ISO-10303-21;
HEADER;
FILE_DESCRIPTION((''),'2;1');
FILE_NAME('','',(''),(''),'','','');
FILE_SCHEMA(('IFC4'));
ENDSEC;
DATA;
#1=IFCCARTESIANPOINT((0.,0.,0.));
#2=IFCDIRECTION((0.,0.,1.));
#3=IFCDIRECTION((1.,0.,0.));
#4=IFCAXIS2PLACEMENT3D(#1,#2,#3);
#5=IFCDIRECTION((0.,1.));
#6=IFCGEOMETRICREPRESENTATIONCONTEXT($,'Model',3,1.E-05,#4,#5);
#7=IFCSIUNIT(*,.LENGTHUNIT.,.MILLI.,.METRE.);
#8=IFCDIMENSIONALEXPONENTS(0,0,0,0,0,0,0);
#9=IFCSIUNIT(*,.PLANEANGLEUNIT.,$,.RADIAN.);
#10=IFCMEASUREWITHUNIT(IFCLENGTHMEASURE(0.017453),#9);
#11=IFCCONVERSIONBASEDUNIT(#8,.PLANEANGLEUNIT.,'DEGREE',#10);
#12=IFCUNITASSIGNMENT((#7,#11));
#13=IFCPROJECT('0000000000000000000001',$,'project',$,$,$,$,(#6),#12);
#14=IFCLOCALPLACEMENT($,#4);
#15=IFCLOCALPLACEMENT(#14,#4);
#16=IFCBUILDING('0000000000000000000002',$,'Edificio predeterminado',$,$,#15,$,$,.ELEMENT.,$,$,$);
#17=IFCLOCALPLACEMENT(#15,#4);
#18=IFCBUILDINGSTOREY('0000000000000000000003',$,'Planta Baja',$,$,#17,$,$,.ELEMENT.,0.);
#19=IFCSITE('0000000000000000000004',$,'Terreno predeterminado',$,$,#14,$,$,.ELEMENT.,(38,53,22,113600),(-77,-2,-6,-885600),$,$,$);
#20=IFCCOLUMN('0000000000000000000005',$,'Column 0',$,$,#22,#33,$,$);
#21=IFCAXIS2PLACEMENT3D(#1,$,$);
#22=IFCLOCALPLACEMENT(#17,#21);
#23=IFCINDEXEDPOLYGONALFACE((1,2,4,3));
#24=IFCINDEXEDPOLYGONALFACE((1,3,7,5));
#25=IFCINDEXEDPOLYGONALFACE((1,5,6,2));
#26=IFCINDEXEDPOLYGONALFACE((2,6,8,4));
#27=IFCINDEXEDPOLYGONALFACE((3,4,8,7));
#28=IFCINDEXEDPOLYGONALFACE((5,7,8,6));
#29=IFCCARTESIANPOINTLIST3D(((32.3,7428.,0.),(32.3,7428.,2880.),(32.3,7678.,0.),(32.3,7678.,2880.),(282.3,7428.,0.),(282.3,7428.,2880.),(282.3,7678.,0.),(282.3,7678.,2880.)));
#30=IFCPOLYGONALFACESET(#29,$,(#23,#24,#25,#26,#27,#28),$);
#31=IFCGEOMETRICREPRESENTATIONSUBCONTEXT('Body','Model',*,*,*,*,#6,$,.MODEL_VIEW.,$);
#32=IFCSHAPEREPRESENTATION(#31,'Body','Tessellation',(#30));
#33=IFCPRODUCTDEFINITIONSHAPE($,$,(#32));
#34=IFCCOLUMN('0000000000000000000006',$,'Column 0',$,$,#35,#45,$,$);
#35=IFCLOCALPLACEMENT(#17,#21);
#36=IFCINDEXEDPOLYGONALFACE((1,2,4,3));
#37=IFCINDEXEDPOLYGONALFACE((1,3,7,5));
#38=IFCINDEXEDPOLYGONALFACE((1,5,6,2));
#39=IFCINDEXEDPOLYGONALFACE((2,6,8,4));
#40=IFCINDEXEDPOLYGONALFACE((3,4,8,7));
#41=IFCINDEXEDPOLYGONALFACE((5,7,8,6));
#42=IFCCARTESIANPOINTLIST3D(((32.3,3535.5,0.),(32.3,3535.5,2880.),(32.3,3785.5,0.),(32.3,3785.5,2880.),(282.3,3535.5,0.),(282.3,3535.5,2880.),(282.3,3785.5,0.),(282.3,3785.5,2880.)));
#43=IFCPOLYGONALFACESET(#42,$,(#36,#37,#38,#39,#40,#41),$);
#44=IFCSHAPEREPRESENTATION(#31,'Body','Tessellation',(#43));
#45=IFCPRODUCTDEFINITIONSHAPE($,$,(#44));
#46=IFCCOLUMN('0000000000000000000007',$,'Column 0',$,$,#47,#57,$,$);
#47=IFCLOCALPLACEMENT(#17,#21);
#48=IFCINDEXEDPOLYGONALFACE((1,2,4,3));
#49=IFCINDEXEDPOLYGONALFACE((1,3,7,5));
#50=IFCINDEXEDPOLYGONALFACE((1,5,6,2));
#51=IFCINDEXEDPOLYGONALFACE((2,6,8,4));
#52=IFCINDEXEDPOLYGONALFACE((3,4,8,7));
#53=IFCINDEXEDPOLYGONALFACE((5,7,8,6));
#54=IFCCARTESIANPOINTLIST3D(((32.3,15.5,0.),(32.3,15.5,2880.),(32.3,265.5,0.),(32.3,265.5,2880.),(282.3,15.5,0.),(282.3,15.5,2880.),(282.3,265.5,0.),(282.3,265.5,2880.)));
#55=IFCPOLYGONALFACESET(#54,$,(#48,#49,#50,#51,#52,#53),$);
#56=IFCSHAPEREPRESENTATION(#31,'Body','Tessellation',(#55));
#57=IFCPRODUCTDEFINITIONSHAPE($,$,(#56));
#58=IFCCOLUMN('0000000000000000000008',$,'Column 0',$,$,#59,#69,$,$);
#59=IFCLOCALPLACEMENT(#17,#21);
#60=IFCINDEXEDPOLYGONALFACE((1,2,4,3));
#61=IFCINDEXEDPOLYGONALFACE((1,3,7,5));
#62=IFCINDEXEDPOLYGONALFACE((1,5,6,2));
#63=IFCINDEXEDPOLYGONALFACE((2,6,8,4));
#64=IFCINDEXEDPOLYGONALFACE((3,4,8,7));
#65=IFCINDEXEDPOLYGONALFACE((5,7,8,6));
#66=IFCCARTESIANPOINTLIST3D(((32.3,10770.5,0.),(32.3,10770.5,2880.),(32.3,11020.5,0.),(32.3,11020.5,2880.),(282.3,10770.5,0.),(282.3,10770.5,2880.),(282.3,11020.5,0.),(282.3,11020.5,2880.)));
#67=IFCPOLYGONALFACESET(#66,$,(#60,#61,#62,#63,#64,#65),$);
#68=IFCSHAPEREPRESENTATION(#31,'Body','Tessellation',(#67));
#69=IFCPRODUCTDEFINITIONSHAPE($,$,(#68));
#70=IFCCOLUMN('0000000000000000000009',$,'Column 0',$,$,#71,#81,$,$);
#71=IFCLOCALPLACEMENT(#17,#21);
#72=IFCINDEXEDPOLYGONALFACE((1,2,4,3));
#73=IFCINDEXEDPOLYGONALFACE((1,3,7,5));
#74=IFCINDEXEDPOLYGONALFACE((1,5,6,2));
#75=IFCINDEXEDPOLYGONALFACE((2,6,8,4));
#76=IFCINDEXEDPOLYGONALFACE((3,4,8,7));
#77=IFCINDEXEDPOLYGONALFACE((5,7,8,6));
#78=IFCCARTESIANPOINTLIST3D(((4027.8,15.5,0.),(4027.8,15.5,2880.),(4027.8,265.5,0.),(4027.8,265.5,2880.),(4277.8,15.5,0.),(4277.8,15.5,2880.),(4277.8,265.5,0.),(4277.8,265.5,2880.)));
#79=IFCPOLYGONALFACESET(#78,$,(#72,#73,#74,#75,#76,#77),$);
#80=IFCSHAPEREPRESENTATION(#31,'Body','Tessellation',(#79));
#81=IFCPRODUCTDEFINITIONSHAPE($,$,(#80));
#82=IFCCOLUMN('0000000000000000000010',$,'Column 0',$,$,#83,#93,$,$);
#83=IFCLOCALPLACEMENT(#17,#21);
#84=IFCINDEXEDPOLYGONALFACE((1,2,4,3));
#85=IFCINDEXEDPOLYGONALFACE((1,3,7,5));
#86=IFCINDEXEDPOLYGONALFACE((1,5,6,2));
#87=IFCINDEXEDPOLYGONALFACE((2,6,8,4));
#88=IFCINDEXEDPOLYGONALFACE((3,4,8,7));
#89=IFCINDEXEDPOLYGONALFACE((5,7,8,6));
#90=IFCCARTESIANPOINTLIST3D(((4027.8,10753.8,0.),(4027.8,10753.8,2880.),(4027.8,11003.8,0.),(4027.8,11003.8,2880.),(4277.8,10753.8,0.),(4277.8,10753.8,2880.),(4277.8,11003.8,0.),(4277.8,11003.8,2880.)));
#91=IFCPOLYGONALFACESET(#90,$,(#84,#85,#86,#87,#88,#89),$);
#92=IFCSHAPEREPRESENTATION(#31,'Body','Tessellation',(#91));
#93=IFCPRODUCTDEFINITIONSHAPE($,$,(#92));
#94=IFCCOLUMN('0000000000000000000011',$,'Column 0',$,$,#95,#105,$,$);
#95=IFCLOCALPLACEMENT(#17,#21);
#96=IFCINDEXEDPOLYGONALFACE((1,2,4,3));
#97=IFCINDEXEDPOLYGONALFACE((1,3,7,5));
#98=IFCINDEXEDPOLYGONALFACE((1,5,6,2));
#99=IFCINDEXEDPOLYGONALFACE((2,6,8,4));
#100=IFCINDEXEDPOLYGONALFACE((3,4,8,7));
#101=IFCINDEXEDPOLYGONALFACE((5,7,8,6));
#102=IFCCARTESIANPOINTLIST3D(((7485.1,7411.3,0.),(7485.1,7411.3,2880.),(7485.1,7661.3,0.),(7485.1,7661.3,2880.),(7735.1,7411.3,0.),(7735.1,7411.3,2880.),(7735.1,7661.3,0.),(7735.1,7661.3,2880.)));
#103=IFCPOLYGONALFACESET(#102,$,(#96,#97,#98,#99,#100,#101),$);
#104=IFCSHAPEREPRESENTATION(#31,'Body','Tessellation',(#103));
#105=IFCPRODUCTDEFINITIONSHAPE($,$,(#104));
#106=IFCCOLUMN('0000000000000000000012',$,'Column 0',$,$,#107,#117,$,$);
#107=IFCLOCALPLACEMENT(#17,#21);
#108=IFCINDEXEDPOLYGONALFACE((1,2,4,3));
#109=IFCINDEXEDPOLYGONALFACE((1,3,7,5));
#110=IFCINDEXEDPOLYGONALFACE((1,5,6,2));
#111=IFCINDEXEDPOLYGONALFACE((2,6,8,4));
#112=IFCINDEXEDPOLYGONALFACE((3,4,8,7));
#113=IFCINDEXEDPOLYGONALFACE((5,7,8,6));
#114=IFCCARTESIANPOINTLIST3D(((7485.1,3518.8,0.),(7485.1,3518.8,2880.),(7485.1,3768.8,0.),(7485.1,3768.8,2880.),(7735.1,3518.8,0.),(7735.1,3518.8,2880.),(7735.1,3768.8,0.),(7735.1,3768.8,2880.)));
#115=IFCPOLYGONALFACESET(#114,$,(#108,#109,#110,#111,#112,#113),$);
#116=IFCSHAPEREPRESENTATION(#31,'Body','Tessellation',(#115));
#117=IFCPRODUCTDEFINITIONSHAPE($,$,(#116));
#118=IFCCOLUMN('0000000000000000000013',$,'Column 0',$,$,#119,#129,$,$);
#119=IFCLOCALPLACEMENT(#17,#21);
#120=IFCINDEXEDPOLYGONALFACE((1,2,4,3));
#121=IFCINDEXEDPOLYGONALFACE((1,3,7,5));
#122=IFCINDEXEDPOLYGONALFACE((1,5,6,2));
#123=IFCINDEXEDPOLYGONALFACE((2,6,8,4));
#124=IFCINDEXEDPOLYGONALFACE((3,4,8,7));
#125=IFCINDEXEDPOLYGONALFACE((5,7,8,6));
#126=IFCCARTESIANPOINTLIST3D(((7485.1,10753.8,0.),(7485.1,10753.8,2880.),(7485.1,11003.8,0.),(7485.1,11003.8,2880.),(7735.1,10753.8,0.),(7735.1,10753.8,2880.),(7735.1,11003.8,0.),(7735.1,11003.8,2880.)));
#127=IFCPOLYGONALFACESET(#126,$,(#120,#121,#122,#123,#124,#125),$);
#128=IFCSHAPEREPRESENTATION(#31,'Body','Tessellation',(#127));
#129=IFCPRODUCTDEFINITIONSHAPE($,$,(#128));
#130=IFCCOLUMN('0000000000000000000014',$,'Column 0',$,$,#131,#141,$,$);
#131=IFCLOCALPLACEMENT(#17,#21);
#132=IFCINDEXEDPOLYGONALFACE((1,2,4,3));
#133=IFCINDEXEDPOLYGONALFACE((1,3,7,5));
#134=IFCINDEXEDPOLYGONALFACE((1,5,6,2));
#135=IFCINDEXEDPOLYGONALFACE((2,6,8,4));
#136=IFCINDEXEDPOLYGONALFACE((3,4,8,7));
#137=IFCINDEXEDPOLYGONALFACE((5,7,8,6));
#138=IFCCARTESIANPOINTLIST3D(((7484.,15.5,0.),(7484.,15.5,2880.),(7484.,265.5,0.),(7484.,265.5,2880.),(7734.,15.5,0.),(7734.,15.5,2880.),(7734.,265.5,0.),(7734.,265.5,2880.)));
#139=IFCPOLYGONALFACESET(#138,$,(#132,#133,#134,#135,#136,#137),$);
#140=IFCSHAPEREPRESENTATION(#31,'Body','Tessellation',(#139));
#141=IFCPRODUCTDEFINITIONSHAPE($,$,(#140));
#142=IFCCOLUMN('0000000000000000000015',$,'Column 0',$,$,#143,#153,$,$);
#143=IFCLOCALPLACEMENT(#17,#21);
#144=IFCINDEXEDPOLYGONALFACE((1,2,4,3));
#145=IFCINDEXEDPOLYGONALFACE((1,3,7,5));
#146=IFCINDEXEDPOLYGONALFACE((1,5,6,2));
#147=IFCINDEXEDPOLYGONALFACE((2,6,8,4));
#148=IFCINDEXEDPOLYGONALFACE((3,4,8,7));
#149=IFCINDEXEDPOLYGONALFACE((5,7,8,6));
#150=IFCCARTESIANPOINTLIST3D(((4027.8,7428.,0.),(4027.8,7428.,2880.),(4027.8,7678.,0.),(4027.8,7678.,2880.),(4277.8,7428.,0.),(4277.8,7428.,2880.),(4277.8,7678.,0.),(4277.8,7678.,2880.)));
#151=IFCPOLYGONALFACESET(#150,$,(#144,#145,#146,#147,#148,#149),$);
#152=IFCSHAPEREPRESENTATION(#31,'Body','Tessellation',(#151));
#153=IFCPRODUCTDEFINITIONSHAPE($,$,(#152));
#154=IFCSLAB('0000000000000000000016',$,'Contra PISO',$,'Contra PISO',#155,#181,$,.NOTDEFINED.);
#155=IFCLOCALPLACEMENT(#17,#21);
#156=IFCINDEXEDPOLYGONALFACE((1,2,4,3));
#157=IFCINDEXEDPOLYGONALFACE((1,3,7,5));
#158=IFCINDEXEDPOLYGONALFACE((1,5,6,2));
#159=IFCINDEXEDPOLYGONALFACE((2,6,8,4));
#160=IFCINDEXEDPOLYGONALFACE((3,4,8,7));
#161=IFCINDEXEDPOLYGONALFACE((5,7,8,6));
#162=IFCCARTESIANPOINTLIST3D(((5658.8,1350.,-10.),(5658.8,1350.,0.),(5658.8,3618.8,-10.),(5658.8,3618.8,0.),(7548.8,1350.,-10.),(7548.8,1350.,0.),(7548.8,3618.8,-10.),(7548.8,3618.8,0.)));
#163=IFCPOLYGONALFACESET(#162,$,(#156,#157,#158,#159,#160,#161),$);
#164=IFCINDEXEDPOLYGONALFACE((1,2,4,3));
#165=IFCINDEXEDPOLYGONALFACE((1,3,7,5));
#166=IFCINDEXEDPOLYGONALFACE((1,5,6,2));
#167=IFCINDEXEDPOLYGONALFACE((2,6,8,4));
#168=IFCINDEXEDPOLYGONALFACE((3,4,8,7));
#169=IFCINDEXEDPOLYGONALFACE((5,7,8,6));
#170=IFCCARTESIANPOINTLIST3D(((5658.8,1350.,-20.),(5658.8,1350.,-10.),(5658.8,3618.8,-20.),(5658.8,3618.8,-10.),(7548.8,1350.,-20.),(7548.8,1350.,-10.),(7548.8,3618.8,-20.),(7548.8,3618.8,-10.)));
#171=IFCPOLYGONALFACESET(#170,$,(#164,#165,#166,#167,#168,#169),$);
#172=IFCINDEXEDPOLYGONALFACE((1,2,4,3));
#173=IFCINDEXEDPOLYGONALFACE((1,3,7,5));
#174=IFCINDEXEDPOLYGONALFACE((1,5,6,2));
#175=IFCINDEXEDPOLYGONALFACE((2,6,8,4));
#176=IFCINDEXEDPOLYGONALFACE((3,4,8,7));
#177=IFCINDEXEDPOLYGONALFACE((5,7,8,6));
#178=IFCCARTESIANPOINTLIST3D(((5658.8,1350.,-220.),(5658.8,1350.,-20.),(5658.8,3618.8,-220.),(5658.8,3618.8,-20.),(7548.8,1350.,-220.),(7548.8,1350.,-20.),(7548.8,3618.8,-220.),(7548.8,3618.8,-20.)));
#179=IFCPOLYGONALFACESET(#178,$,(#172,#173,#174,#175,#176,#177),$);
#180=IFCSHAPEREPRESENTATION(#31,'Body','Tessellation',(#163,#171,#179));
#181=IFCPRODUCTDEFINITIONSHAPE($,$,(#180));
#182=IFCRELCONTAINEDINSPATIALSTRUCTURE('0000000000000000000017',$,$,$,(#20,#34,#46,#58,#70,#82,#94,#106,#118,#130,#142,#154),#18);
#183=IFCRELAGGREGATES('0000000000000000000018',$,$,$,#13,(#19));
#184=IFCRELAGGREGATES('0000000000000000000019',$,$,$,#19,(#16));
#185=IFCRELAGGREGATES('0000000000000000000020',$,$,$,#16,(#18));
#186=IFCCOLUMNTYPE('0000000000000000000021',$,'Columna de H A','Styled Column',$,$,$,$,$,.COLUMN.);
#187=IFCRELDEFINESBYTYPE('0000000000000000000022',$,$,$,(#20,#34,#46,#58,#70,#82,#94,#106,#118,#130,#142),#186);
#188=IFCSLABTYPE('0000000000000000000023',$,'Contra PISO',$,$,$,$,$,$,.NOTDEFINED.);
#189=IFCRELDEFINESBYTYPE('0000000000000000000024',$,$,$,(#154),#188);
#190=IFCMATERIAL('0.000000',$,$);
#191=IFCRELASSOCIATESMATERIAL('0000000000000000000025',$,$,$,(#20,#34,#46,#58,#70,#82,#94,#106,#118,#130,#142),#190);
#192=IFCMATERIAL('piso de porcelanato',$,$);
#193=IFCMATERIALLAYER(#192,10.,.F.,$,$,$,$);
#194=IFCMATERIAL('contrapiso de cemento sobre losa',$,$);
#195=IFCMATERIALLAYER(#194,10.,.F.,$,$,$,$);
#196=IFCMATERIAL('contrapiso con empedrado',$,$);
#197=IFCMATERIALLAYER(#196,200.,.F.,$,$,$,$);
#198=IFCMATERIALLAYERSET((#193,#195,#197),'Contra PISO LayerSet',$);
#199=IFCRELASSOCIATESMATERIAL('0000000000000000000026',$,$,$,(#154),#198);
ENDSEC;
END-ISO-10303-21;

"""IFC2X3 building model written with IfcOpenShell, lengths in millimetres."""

from ifc_helpers import new_model, entity, si_unit, converted_unit, direction, frame, origin_with_axes, place, context, subcontext, project, spatial, polyline, outline, extrude, material, layer, layer_set, layer_usage, type_object, element, save


model = new_model("IFC2X3")

# Units and contexts
model_context = context("Model", 3, precision=1e-05, world=origin_with_axes(), true_north=direction((0.0, 1.0)))
body_context = subcontext(model_context, "Body", "Model", "MODEL_VIEW")
ifc_project = project(units=[si_unit("LENGTHUNIT", "METRE", prefix="MILLI"), converted_unit("PLANEANGLEUNIT", "DEGREE", entity("IfcLengthMeasure", 0.017453), si_unit("PLANEANGLEUNIT", "RADIAN"), dimensions=[0, 0, 0, 0, 0, 0, 0])], contexts=[model_context])

# Site, building, storey
site_placement = place(None, origin_with_axes())
site = spatial("IfcSite", under=ifc_project, at=site_placement, Name="Terreno predeterminado", CompositionType="ELEMENT", RefLatitude=(38, 53, 22, 113600), RefLongitude=(-77, -2, -6, -885600))
building_placement = place(site_placement, origin_with_axes())
building = spatial("IfcBuilding", under=site, at=building_placement, Name="Edificio predeterminado", CompositionType="ELEMENT")
storey_placement = place(building_placement, origin_with_axes())
storey = spatial("IfcBuildingStorey", under=building, at=storey_placement, Name="Planta Baja", CompositionType="ELEMENT", Elevation=0.0)

# Columns
ifc_material_1 = material(Name="0.000000")
column_type = type_object("IfcColumnType", Name="Columna de H A", Description="Styled Column", PredefinedType="COLUMN")
for number, where, z_axis, x_axis, name in (
    (1, (157.3, 7553.0, 0.0), (0.0, 0.0, 1.0), (1.0, 0.0, 0.0), "Column 0"),
    (2, (157.3, 3660.5, 0.0), (0.0, 0.0, 1.0), (1.0, 0.0, 0.0), "Column 0"),
    (3, (157.3, 140.5, 0.0), (0.0, 0.0, 1.0), (1.0, 0.0, 0.0), "Column 0"),
    (4, (157.3, 10895.5, 0.0), (0.0, 0.0, 1.0), (1.0, 0.0, 0.0), "Column 0"),
    (5, (4152.8, 140.5, 0.0), (0.0, 0.0, 1.0), (1.0, 0.0, 0.0), "Column 0"),
    (6, (4152.8, 10878.8, 0.0), (0.0, 0.0, 1.0), (1.0, 0.0, 0.0), "Column 0"),
    (7, (7610.1, 7536.3, 0.0), (0.0, 0.0, 1.0), (1.0, 0.0, 0.0), "Column 0"),
    (8, (7610.1, 3643.8, 0.0), (0.0, 0.0, 1.0), (1.0, 0.0, 0.0), "Column 0"),
    (9, (7610.1, 10878.8, 0.0), (0.0, 0.0, 1.0), (1.0, 0.0, 0.0), "Column 0"),
    (10, (7609.0, 140.5, 0.0), (0.0, 0.0, 1.0), (1.0, 0.0, 0.0), "Column 0"),
    (11, (4152.8, 7553.0, 0.0), (0.0, 0.0, 1.0), (1.0, 0.0, 0.0), "Column 0"),
):
    element("IfcColumn", number, at=place(storey_placement, frame(where, z_axis=z_axis, x_axis=x_axis)), inside=storey, type_object=column_type, material=ifc_material_1, Name=name, context=body_context, shape_type="SweptSolid", body=[
        extrude(outline(polyline([(-125.0, -125.0), (125.0, -125.0), (125.0, 125.0), (-125.0, 125.0), (-125.0, -125.0)])), origin_with_axes(), (0.0, 0.0, 1.0), 2880.0),
    ])

# Slab
ifc_material_2 = material(Name="piso de porcelanato")
ifc_layer_1 = layer(ifc_material_2, 10.0, ventilated=False)
ifc_material_3 = material(Name="contrapiso de cemento sobre losa")
ifc_layer_2 = layer(ifc_material_3, 10.0, ventilated=False)
ifc_material_4 = material(Name="contrapiso con empedrado")
ifc_layer_3 = layer(ifc_material_4, 200.0, ventilated=False)
ifc_layer_set_1 = layer_set([ifc_layer_1, ifc_layer_2, ifc_layer_3], Name="Contra PISO LayerSet")
ifc_layer_usage_1 = layer_usage(ifc_layer_set_1, "AXIS3", "NEGATIVE", 0.0)
slab_type = type_object("IfcSlabType", Name="Contra PISO", PredefinedType="NOTDEFINED")
slab_1_placement = place(storey_placement, origin_with_axes())
element("IfcSlab", 12, at=slab_1_placement, inside=storey, type_object=slab_type, material=ifc_layer_usage_1, Name="Contra PISO", ObjectType="Contra PISO", PredefinedType="NOTDEFINED", context=body_context, shape_type="SweptSolid", body=[
    extrude(outline(polyline([(0.0, 2268.8), (1890.0, 2268.8), (1890.0, 0.0), (0.0, 0.0), (0.0, 2268.8)])), frame((7548.8, 1350.0, -10.0), z_axis=(0.0, 0.0, -1.0), x_axis=(-1.0, 0.0, 0.0)), (0.0, 0.0, -1.0), 10.0),
    extrude(outline(polyline([(0.0, 2268.8), (1890.0, 2268.8), (1890.0, 0.0), (0.0, 0.0), (0.0, 2268.8)])), frame((7548.8, 1350.0, -20.0), z_axis=(0.0, 0.0, -1.0), x_axis=(-1.0, 0.0, 0.0)), (0.0, 0.0, -1.0), 10.0),
    extrude(outline(polyline([(0.0, 2268.8), (1890.0, 2268.8), (1890.0, 0.0), (0.0, 0.0), (0.0, 2268.8)])), frame((7548.8, 1350.0, -220.0), z_axis=(0.0, 0.0, -1.0), x_axis=(-1.0, 0.0, 0.0)), (0.0, 0.0, -1.0), 200.0),
])

save(model, "model.ifc")
